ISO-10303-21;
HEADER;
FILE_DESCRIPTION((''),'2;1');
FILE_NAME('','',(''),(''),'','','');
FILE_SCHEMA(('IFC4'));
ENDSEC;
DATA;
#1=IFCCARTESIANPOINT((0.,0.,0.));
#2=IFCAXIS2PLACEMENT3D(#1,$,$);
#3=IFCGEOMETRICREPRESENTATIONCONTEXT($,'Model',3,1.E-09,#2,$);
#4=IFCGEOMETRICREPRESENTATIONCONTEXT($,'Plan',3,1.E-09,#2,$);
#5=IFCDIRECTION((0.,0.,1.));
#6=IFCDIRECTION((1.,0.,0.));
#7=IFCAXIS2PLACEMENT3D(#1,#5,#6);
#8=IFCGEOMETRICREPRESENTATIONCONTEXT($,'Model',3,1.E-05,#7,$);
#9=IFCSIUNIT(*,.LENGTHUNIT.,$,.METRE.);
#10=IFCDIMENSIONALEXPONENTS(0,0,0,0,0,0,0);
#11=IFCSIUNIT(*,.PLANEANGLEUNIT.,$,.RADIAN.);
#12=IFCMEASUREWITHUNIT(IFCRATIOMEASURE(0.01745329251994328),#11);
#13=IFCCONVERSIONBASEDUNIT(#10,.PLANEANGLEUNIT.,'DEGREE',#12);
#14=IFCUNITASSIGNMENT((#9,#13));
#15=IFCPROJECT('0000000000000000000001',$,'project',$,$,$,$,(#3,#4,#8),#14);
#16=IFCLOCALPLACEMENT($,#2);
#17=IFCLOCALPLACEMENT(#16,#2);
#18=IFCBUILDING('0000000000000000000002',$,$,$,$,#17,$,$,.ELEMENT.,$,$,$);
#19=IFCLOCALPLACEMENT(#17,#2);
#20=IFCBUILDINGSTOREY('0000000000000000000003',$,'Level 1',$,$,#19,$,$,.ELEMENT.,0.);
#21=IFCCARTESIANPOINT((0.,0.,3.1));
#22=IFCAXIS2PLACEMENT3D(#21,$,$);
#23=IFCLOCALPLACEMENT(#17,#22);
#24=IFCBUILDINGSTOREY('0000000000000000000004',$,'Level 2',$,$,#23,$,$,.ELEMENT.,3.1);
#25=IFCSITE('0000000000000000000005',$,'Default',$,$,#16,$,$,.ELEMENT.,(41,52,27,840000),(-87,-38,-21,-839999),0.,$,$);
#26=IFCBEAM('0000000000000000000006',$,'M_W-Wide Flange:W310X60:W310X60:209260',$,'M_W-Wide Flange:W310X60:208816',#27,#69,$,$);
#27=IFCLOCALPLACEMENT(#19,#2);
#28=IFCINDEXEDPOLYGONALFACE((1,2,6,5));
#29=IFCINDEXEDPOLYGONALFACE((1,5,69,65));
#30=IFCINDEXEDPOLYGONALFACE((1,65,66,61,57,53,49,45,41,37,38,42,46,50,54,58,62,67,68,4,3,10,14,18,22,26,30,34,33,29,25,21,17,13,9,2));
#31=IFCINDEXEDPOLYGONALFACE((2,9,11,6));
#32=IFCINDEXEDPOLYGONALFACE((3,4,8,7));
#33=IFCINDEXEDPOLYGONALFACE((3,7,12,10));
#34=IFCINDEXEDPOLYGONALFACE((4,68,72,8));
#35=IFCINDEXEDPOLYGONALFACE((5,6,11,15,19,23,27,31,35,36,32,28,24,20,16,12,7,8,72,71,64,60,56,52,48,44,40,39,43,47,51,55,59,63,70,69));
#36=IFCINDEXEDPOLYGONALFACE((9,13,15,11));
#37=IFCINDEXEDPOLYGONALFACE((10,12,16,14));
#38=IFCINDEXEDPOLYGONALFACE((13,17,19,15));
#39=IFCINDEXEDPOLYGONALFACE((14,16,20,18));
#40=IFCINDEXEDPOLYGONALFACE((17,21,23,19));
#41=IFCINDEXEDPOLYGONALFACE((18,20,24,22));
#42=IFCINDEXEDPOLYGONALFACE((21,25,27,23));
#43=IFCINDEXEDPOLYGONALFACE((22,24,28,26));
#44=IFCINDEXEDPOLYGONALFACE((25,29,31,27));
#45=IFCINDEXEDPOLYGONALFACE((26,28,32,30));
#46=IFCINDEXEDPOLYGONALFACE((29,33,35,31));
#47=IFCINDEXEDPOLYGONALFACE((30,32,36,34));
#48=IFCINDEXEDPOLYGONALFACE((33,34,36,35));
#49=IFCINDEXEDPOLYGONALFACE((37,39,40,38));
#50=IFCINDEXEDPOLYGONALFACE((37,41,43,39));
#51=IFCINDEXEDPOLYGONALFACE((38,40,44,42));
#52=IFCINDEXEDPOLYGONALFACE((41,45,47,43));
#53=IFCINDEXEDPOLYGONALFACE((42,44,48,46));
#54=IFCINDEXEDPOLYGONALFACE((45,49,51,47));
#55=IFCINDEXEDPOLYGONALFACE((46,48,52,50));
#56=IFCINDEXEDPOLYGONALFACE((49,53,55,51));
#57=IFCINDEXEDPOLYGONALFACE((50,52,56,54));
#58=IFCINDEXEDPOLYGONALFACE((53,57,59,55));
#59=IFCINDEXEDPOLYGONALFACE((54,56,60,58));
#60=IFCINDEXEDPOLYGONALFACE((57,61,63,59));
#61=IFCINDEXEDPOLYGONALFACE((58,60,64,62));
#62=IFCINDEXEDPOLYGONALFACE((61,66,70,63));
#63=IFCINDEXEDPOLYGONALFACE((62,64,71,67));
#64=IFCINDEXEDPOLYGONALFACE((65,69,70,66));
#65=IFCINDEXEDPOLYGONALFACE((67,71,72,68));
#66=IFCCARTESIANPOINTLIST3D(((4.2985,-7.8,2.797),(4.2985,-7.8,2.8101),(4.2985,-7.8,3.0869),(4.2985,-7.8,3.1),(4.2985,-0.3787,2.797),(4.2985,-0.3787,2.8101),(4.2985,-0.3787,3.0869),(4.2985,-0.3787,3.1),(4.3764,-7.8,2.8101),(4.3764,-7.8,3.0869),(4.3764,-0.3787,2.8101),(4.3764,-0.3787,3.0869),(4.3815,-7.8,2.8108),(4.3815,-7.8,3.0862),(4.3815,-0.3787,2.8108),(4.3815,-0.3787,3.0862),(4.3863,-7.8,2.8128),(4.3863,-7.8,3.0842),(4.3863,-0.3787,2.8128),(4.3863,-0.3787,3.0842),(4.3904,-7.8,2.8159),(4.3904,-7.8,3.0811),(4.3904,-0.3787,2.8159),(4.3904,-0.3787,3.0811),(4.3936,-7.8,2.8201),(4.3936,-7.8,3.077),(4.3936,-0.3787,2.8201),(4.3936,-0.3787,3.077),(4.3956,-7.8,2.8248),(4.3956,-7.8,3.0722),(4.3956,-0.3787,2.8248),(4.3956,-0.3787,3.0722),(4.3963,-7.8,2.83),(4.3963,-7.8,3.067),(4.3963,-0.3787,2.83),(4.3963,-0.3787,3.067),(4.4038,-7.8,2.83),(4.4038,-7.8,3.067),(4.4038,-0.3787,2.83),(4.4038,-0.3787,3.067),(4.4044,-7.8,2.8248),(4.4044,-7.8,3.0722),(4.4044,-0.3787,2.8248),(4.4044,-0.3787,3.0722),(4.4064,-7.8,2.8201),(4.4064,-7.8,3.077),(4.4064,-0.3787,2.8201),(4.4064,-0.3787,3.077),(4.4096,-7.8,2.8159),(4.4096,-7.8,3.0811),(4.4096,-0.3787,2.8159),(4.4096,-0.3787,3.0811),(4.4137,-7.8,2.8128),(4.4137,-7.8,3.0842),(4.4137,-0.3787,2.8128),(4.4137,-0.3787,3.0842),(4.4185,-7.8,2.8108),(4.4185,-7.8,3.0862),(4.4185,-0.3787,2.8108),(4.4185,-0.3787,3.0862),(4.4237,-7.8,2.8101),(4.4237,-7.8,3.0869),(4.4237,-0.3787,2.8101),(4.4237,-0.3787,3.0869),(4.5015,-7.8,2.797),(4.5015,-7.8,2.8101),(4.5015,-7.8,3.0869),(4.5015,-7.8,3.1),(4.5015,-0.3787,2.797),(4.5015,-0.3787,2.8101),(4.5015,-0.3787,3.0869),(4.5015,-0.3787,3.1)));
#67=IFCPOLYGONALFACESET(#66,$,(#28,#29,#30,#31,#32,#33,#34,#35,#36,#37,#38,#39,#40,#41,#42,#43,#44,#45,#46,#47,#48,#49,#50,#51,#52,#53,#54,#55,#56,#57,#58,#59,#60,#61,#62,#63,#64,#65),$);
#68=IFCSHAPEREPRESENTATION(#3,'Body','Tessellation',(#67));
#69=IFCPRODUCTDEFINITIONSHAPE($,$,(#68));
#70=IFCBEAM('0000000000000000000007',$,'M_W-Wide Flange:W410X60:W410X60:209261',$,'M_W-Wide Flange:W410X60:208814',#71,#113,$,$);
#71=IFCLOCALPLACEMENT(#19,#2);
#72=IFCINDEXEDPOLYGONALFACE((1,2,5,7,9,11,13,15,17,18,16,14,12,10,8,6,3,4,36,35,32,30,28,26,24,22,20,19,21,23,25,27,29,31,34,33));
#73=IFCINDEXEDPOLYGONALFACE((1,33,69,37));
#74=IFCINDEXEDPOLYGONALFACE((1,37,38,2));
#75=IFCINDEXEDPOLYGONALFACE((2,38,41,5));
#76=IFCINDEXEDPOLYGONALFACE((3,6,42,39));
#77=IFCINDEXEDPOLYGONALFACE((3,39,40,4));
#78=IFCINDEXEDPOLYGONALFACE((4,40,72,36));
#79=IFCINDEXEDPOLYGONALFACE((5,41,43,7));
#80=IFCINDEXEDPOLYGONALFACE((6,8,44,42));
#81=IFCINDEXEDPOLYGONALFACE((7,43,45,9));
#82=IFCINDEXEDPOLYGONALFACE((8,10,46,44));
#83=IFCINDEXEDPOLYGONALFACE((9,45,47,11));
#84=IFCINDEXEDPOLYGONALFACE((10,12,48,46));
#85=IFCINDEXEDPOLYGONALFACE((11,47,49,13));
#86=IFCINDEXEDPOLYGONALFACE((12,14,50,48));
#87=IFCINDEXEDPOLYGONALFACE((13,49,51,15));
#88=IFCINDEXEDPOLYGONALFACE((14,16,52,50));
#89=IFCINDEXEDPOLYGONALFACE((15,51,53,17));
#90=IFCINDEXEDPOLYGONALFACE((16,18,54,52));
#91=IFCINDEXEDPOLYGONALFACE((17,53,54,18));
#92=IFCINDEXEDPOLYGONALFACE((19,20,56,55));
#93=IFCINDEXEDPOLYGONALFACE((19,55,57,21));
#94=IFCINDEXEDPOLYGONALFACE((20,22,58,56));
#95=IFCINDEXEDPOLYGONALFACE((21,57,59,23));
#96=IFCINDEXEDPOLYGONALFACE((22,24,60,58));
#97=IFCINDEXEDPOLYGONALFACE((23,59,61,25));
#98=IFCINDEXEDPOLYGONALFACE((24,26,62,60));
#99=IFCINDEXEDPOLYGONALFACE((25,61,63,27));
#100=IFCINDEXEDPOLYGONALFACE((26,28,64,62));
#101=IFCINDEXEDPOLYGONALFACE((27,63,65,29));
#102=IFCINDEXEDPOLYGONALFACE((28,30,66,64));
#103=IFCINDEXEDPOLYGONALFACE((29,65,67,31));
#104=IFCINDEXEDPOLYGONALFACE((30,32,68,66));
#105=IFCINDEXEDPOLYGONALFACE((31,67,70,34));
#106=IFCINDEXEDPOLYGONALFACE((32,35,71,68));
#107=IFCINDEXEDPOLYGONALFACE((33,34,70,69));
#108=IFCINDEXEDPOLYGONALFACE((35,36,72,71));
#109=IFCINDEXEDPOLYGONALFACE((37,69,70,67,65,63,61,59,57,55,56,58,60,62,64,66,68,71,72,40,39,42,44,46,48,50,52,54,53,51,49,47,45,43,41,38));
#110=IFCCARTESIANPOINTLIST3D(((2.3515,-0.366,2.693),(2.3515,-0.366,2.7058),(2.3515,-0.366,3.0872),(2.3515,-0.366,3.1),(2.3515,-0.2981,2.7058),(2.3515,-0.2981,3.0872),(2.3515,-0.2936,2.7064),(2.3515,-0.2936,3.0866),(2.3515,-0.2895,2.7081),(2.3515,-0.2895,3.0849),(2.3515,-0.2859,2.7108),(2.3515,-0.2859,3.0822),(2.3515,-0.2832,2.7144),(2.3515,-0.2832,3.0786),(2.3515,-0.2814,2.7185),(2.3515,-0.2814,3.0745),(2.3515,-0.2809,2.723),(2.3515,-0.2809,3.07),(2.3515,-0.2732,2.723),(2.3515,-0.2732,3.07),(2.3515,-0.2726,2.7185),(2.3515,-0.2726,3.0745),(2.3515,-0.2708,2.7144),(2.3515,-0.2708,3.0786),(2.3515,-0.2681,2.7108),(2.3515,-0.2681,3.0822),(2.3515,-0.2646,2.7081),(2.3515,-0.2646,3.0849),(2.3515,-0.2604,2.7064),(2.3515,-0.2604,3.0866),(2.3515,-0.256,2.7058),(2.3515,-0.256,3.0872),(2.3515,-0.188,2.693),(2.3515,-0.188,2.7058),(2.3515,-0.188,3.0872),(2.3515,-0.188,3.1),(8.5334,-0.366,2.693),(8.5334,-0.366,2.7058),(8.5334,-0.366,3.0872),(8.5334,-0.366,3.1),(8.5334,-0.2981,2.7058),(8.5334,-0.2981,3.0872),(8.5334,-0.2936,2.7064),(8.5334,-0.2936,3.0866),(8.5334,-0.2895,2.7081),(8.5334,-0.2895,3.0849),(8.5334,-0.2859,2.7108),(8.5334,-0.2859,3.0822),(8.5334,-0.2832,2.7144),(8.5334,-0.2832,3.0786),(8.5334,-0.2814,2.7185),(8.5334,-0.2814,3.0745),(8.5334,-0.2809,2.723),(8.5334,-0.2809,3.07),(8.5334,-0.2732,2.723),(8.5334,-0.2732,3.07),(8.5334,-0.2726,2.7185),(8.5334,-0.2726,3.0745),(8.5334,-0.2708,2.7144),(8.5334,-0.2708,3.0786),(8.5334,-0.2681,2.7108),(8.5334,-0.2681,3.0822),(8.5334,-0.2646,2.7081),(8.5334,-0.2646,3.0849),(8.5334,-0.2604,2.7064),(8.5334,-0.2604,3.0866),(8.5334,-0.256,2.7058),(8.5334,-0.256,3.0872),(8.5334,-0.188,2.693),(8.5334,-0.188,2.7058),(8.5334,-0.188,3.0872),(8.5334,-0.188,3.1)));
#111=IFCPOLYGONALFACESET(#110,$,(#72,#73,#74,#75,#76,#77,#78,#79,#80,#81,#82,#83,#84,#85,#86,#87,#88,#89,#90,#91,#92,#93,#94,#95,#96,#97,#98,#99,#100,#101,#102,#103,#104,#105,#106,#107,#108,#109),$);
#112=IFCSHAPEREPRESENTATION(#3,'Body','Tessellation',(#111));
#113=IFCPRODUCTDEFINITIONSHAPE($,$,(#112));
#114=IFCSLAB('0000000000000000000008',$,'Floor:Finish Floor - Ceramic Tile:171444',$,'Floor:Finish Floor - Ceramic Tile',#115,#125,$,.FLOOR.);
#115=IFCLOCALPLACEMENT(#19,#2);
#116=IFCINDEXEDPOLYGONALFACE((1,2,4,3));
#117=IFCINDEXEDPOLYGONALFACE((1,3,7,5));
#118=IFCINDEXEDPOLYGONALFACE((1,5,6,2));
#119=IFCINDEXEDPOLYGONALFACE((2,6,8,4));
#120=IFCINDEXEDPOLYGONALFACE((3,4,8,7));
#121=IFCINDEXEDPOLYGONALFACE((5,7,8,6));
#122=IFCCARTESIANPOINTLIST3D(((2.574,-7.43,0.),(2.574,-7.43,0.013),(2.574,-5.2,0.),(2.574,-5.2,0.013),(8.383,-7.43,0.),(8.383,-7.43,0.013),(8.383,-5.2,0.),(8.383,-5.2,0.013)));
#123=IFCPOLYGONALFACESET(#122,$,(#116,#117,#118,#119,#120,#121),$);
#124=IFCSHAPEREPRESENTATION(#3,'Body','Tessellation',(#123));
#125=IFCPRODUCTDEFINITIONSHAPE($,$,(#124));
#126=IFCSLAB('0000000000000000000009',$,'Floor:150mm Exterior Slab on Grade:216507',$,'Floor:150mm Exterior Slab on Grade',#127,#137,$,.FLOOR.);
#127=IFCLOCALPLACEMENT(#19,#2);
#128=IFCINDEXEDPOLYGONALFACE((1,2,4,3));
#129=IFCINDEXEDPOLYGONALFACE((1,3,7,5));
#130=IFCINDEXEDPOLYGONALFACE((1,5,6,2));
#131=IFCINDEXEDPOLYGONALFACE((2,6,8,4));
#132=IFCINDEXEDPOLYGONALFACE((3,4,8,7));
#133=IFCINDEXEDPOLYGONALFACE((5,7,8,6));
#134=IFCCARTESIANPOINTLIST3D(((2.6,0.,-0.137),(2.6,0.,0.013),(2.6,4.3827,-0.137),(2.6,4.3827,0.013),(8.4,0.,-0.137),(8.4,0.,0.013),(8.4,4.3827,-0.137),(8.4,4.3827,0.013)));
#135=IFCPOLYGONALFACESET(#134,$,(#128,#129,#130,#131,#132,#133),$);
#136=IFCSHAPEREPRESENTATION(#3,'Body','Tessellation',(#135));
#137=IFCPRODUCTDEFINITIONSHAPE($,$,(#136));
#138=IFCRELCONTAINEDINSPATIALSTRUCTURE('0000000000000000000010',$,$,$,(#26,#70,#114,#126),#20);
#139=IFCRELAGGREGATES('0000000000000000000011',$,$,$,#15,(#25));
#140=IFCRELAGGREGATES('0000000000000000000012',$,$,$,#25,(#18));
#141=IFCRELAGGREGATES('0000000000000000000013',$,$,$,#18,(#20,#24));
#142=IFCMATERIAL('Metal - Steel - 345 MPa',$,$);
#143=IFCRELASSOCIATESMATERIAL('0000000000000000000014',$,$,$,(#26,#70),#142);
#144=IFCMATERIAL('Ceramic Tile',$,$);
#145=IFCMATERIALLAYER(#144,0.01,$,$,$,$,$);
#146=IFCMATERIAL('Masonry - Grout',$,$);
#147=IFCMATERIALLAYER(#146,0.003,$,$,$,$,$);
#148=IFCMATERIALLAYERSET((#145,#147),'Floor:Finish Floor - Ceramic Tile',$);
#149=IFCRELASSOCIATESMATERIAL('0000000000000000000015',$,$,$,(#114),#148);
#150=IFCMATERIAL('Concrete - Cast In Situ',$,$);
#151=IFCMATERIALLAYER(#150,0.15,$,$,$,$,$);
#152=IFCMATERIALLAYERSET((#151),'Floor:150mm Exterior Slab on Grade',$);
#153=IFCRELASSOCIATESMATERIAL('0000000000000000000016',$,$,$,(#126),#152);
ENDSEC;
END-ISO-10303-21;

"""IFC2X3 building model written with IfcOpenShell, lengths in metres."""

from ifc_helpers import new_model, entity, si_unit, converted_unit, frame, frame_2d, origin, origin_with_axes, place, context, project, spatial, polyline, circle_curve, parameter, trimmed, segment, composite_curve, rectangle, outline, extrude, material, layer, layer_set, layer_usage, element, save


model = new_model("IFC2X3")

# Units and contexts
model_context_1 = context("Model", 3, precision=1e-09, world=origin())
plan_context = context("Plan", 3, precision=1e-09, world=origin())
model_context_2 = context("Model", 3, precision=1e-05, world=origin_with_axes())
ifc_project = project(units=[si_unit("LENGTHUNIT", "METRE"), converted_unit("PLANEANGLEUNIT", "DEGREE", entity("IfcRatioMeasure", 0.01745329251994328), si_unit("PLANEANGLEUNIT", "RADIAN"), dimensions=[0, 0, 0, 0, 0, 0, 0])], contexts=[model_context_1, plan_context, model_context_2])

# Site, building, storey
site_placement = place(None, origin())
site = spatial("IfcSite", under=ifc_project, at=site_placement, Name="Default", CompositionType="ELEMENT", RefLatitude=(41, 52, 27, 840000), RefLongitude=(-87, -38, -21, -839999), RefElevation=0.0)
building_placement = place(site_placement, origin())
building = spatial("IfcBuilding", under=site, at=building_placement, CompositionType="ELEMENT")
storey_1_placement = place(building_placement, origin())
storey_1 = spatial("IfcBuildingStorey", under=building, at=storey_1_placement, Name="Level 1", CompositionType="ELEMENT", Elevation=0.0)

# Beams
ifc_material_1 = material(Name="Metal - Steel - 345 MPa")
beam_1_placement = place(storey_1_placement, frame((4.4, -7.8, 3.1)))
element("IfcBeam", 1, at=beam_1_placement, inside=storey_1, material=ifc_material_1, Name="M_W-Wide Flange:W310X60:W310X60:209260", ObjectType="M_W-Wide Flange:W310X60:208816", context=model_context_1, shape_type="SweptSolid", body=[
    extrude(outline(composite_curve([segment(polyline([(-0.1015, -0.1384), (-0.1015, -0.1515)]), True, "CONTINUOUS"), segment(polyline([(-0.1015, -0.1515), (0.1015, -0.1515)]), True, "CONTINUOUS"), segment(polyline([(0.1015, -0.1515), (0.1015, -0.1384)]), True, "CONTINUOUS"), segment(polyline([(0.1015, -0.1384), (0.0236, -0.1384)]), True, "CONTINUOUS"), segment(trimmed(circle_curve(frame_2d((0.0236, -0.1185), x_axis=(1.0, 0.0)), 0.0199), [parameter(180.0)], [parameter(270.0)], True, "PARAMETER"), False, "CONTINUOUS"), segment(polyline([(0.0037, -0.1185), (0.0037, 0.1185)]), True, "CONTINUOUS"), segment(trimmed(circle_curve(frame_2d((0.0236, 0.1185), x_axis=(1.0, 0.0)), 0.0199), [parameter(90.0)], [parameter(180.0)], True, "PARAMETER"), False, "CONTINUOUS"), segment(polyline([(0.0236, 0.1384), (0.1015, 0.1384)]), True, "CONTINUOUS"), segment(polyline([(0.1015, 0.1384), (0.1015, 0.1515)]), True, "CONTINUOUS"), segment(polyline([(0.1015, 0.1515), (-0.1015, 0.1515)]), True, "CONTINUOUS"), segment(polyline([(-0.1015, 0.1515), (-0.1015, 0.1384)]), True, "CONTINUOUS"), segment(polyline([(-0.1015, 0.1384), (-0.0237, 0.1384)]), True, "CONTINUOUS"), segment(trimmed(circle_curve(frame_2d((-0.0237, 0.1185), x_axis=(1.0, 0.0)), 0.0199), [parameter(360.0)], [parameter(90.0)], True, "PARAMETER"), False, "CONTINUOUS"), segment(polyline([(-0.0038, 0.1185), (-0.0038, -0.1185)]), True, "CONTINUOUS"), segment(trimmed(circle_curve(frame_2d((-0.0237, -0.1185), x_axis=(1.0, 0.0)), 0.0199), [parameter(270.0)], [parameter(0.0)], True, "PARAMETER"), False, "CONTINUOUS"), segment(polyline([(-0.0237, -0.1384), (-0.1015, -0.1384)]), True, "CONTINUOUS")], self_intersect=False)), frame((0.0, 0.0, -0.1515), z_axis=(0.0, -1.0, 0.0), x_axis=(1.0, 0.0, 0.0)), (0.0, 0.0, -1.0), 7.4213),
])
beam_2_placement = place(storey_1_placement, frame((8.5915, -0.277, 3.1), z_axis=(0.0, 0.0, 1.0), x_axis=(0.0, 1.0, 0.0)))
element("IfcBeam", 2, at=beam_2_placement, inside=storey_1, material=ifc_material_1, Name="M_W-Wide Flange:W410X60:W410X60:209261", ObjectType="M_W-Wide Flange:W410X60:208814", context=model_context_1, shape_type="SweptSolid", body=[
    extrude(outline(composite_curve([segment(polyline([(0.1907, -0.089), (0.2035, -0.089)]), True, "CONTINUOUS"), segment(polyline([(0.2035, -0.089), (0.2035, 0.089)]), True, "CONTINUOUS"), segment(polyline([(0.2035, 0.089), (0.1907, 0.089)]), True, "CONTINUOUS"), segment(polyline([(0.1907, 0.089), (0.1907, 0.021)]), True, "CONTINUOUS"), segment(trimmed(circle_curve(frame_2d((0.1735, 0.021), x_axis=(1.0, 0.0)), 0.0172), [parameter(270.0)], [parameter(360.0)], True, "PARAMETER"), False, "CONTINUOUS"), segment(polyline([(0.1735, 0.0038), (-0.1735, 0.0038)]), True, "CONTINUOUS"), segment(trimmed(circle_curve(frame_2d((-0.1735, 0.021), x_axis=(0.0, -1.0)), 0.0172), [parameter(270.0)], [parameter(360.0)], True, "PARAMETER"), False, "CONTINUOUS"), segment(polyline([(-0.1907, 0.021), (-0.1907, 0.089)]), True, "CONTINUOUS"), segment(polyline([(-0.1907, 0.089), (-0.2035, 0.089)]), True, "CONTINUOUS"), segment(polyline([(-0.2035, 0.089), (-0.2035, -0.089)]), True, "CONTINUOUS"), segment(polyline([(-0.2035, -0.089), (-0.1907, -0.089)]), True, "CONTINUOUS"), segment(polyline([(-0.1907, -0.089), (-0.1907, -0.0211)]), True, "CONTINUOUS"), segment(trimmed(circle_curve(frame_2d((-0.1735, -0.0211), x_axis=(-1.0, 0.0)), 0.0172), [parameter(270.0)], [parameter(0.0)], True, "PARAMETER"), False, "CONTINUOUS"), segment(polyline([(-0.1735, -0.0039), (0.1735, -0.0039)]), True, "CONTINUOUS"), segment(trimmed(circle_curve(frame_2d((0.1735, -0.0211), x_axis=(0.0, 1.0)), 0.0172), [parameter(270.0)], [parameter(0.0)], True, "PARAMETER"), False, "CONTINUOUS"), segment(polyline([(0.1907, -0.0211), (0.1907, -0.089)]), True, "CONTINUOUS")], self_intersect=False)), frame((0.0, 6.24, -0.2035), z_axis=(0.0, -1.0, 0.0), x_axis=(0.0, 0.0, -1.0)), (0.0, 0.0, 1.0), 6.1819),
])

# Slabs
ifc_material_2 = material(Name="Ceramic Tile")
ifc_layer_1 = layer(ifc_material_2, 0.01)
ifc_material_3 = material(Name="Masonry - Grout")
ifc_layer_2 = layer(ifc_material_3, 0.003)
ifc_layer_set_1 = layer_set([ifc_layer_1, ifc_layer_2], Name="Floor:Finish Floor - Ceramic Tile")
ifc_layer_usage_1 = layer_usage(ifc_layer_set_1, "AXIS3", "POSITIVE", 0.0)
slab_1_placement = place(storey_1_placement, frame((2.574, -7.43, 0.0)))
element("IfcSlab", 3, at=slab_1_placement, inside=storey_1, material=ifc_layer_usage_1, Name="Floor:Finish Floor - Ceramic Tile:171444", ObjectType="Floor:Finish Floor - Ceramic Tile", PredefinedType="FLOOR", context=model_context_1, shape_type="SweptSolid", body=[
    extrude(rectangle(XDim=5.809, YDim=2.23, at=frame_2d((0.0, 0.0), x_axis=(-1.0, 0.0))), frame((2.9045, 1.115, 0.013), z_axis=(0.0, 0.0, -1.0), x_axis=(-1.0, 0.0, 0.0)), (0.0, 0.0, 1.0), 0.013),
])
ifc_material_4 = material(Name="Concrete - Cast In Situ")
ifc_layer_3 = layer(ifc_material_4, 0.15)
ifc_layer_set_2 = layer_set([ifc_layer_3], Name="Floor:150mm Exterior Slab on Grade")
ifc_layer_usage_2 = layer_usage(ifc_layer_set_2, "AXIS3", "POSITIVE", 0.0)
slab_2_placement = place(storey_1_placement, frame((2.6, 0.0, -0.137)))
element("IfcSlab", 4, at=slab_2_placement, inside=storey_1, material=ifc_layer_usage_2, Name="Floor:150mm Exterior Slab on Grade:216507", ObjectType="Floor:150mm Exterior Slab on Grade", PredefinedType="FLOOR", context=model_context_1, shape_type="SweptSolid", body=[
    extrude(rectangle(XDim=5.8, YDim=4.3827, at=frame_2d((0.0, 0.0), x_axis=(-1.0, 0.0))), frame((2.9, 2.1914, 0.15), z_axis=(0.0, 0.0, -1.0), x_axis=(-1.0, 0.0, 0.0)), (0.0, 0.0, 1.0), 0.15),
])

# Shared definitions
storey_2_placement = place(building_placement, frame((0.0, 0.0, 3.1)))
storey_2 = spatial("IfcBuildingStorey", under=building, at=storey_2_placement, Name="Level 2", CompositionType="ELEMENT", Elevation=3.1)

save(model, "model.ifc")
